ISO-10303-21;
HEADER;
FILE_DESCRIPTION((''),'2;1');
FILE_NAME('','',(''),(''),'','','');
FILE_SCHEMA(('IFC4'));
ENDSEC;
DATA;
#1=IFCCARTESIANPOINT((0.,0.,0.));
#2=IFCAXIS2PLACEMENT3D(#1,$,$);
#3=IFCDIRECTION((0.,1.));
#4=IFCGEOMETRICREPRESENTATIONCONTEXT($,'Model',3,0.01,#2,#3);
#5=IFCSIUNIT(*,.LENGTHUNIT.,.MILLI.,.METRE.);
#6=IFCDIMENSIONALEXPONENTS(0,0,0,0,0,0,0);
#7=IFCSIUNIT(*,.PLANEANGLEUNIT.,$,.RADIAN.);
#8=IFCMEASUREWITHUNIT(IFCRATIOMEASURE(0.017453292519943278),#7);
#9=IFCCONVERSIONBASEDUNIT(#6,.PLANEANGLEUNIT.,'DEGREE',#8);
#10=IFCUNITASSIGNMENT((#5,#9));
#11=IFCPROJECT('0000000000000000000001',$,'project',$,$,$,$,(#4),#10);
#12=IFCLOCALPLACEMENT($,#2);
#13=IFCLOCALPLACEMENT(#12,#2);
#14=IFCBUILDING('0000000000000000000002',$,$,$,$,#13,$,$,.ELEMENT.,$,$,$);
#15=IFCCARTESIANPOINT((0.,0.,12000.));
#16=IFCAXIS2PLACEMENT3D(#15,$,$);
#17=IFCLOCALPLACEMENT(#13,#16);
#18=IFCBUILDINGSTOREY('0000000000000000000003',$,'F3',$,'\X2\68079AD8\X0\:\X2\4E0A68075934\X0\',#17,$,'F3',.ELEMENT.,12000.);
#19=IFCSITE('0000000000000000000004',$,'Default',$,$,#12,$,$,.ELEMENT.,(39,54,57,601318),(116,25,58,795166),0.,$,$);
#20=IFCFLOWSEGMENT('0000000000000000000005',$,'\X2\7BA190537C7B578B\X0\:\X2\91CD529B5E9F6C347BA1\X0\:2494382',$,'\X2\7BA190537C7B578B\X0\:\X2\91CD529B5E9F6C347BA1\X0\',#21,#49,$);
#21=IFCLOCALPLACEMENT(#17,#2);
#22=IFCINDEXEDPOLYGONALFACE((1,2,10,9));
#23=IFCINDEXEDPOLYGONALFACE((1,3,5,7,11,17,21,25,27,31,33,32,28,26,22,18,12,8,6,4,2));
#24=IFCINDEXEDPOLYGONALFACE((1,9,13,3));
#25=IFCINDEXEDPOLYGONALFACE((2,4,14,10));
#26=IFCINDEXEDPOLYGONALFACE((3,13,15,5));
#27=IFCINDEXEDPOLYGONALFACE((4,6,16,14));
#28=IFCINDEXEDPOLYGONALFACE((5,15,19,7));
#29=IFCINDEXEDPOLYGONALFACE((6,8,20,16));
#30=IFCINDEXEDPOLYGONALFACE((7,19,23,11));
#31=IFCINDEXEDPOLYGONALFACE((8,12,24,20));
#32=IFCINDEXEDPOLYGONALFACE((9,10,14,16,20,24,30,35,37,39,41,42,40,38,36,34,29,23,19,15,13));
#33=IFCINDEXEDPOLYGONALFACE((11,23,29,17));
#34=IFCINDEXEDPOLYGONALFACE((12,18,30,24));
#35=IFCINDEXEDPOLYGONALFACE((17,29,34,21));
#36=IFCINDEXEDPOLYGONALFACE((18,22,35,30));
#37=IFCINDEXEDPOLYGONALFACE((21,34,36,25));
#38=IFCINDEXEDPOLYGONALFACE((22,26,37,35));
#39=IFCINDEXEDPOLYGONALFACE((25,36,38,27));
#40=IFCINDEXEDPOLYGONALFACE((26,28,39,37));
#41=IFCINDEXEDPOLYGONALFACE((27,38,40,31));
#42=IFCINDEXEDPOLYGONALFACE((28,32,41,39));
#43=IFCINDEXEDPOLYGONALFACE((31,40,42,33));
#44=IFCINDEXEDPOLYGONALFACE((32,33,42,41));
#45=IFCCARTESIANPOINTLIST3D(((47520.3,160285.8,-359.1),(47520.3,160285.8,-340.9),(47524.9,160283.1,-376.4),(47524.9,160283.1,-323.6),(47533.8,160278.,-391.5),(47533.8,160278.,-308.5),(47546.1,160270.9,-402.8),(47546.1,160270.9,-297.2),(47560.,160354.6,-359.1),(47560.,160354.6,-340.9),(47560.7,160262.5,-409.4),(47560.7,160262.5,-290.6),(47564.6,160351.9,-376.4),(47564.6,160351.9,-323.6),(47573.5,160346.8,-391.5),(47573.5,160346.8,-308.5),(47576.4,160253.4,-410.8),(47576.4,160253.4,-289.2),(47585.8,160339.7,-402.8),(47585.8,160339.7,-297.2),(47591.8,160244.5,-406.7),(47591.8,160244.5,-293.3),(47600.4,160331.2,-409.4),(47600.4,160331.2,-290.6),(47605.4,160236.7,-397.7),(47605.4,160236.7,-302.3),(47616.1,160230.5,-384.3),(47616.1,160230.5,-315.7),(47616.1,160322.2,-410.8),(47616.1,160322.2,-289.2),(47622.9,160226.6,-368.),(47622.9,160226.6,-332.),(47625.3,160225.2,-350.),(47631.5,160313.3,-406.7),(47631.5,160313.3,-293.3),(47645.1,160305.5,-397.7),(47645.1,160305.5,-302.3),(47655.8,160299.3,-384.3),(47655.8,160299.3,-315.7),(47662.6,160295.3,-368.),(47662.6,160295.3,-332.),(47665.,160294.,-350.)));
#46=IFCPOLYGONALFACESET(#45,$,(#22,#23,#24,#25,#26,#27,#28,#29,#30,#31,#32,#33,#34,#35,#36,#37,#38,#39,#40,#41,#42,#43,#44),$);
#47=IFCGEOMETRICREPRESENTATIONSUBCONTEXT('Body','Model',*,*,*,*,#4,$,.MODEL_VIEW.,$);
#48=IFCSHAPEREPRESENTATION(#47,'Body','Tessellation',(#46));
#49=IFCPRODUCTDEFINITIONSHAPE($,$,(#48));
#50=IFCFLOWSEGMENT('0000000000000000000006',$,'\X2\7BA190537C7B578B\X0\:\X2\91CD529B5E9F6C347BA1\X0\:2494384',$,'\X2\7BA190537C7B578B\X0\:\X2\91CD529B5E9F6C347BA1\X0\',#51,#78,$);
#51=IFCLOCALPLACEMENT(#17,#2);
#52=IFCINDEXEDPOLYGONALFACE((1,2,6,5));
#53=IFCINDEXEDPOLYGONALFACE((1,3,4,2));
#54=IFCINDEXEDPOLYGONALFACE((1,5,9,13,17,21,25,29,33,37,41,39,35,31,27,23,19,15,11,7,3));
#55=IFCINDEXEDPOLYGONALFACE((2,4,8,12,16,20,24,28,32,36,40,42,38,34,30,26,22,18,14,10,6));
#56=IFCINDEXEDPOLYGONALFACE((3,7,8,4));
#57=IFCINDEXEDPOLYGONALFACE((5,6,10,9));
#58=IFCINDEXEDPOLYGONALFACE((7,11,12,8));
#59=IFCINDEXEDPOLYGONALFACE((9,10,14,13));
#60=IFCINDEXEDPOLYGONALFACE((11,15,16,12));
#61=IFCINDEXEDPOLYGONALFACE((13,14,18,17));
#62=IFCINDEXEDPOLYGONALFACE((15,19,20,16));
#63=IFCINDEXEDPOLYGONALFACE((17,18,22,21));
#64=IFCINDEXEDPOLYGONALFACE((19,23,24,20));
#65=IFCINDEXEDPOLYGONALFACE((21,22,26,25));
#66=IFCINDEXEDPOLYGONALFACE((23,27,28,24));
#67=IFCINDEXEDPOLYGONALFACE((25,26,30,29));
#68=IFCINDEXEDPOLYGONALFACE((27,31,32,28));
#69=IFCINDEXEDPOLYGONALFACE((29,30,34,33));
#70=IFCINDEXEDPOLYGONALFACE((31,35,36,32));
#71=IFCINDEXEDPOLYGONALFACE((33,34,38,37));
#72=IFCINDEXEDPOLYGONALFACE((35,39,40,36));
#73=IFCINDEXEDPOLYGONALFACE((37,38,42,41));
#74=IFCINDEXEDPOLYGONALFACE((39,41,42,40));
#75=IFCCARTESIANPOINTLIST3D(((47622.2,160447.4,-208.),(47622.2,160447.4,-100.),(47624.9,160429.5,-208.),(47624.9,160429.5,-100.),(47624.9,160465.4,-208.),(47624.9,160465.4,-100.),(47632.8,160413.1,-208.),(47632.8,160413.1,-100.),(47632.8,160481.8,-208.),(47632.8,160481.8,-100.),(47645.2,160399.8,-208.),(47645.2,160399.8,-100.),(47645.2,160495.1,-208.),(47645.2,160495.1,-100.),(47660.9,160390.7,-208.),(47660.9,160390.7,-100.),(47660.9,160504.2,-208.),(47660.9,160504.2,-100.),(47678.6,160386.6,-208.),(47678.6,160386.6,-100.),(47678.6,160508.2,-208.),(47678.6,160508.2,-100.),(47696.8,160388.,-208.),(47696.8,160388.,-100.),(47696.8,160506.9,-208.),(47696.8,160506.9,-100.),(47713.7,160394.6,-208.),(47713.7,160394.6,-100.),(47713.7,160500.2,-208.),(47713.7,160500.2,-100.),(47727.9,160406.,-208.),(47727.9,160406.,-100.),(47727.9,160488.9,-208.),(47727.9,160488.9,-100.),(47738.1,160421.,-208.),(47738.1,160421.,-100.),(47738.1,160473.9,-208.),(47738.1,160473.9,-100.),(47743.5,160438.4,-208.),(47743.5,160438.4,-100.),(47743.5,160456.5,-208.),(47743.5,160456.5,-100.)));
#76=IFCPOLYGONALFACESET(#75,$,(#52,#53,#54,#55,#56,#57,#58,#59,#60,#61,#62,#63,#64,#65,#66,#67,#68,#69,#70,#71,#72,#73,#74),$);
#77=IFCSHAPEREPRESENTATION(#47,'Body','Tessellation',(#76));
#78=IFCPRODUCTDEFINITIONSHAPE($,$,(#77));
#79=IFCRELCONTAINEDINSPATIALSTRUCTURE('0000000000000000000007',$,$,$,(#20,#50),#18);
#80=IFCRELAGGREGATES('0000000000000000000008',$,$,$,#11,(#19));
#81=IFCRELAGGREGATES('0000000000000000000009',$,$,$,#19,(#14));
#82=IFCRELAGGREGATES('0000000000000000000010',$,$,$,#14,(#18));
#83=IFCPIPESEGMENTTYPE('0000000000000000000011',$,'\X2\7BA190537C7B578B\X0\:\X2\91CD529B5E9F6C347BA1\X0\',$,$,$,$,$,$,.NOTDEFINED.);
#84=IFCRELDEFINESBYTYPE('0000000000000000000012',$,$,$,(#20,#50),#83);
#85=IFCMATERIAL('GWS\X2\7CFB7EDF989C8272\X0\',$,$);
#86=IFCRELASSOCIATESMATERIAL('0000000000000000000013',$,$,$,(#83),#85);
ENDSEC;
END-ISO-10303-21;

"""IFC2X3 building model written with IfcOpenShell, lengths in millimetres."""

from ifc_helpers import new_model, entity, si_unit, converted_unit, direction, frame, frame_2d, origin, origin_2d_with_axis, place, context, subcontext, project, spatial, circle, extrude, material, type_object, element, save


model = new_model("IFC2X3")

# Units and contexts
model_context = context("Model", 3, precision=0.01, world=origin(), true_north=direction((0.0, 1.0)))
body_context = subcontext(model_context, "Body", "Model", "MODEL_VIEW")
ifc_project = project(units=[si_unit("LENGTHUNIT", "METRE", prefix="MILLI"), converted_unit("PLANEANGLEUNIT", "DEGREE", entity("IfcRatioMeasure", 0.017453292519943278), si_unit("PLANEANGLEUNIT", "RADIAN"), dimensions=[0, 0, 0, 0, 0, 0, 0])], contexts=[model_context])

# Site, building, storey
site_placement = place(None, origin())
site = spatial("IfcSite", under=ifc_project, at=site_placement, Name="Default", CompositionType="ELEMENT", RefLatitude=(39, 54, 57, 601318), RefLongitude=(116, 25, 58, 795166), RefElevation=0.0)
building_placement = place(site_placement, origin())
building = spatial("IfcBuilding", under=site, at=building_placement, CompositionType="ELEMENT")
storey_placement = place(building_placement, frame((0.0, 0.0, 12000.0)))
storey = spatial("IfcBuildingStorey", under=building, at=storey_placement, Name="F3", ObjectType="标高:上标头", LongName="F3", CompositionType="ELEMENT", Elevation=12000.0)

# Flow segments
ifc_material = material(Name="GWS系统颜色")
pipe_segment_type = type_object("IfcPipeSegmentType", Name="管道类型:重力废水管", PredefinedType="NOTDEFINED", material=ifc_material)
flow_segment_1_placement = place(storey_placement, origin())
element("IfcFlowSegment", 1, at=flow_segment_1_placement, inside=storey, type_object=pipe_segment_type, Name="管道类型:重力废水管:2494382", ObjectType="管道类型:重力废水管", context=body_context, shape_type="SweptSolid", body=[
    extrude(circle(Radius=61.0, at=frame_2d((0.0, 0.0), x_axis=(1.0, 0.0))), frame((47572.5, 160255.7, -350.0), z_axis=(0.5, 0.866025, 0.0), x_axis=(0.866025, -0.5, 0.0)), (0.0, 0.0, 1.0), 79.4),
])
flow_segment_2_placement = place(storey_placement, origin())
element("IfcFlowSegment", 2, at=flow_segment_2_placement, inside=storey, type_object=pipe_segment_type, Name="管道类型:重力废水管:2494384", ObjectType="管道类型:重力废水管", context=body_context, shape_type="SweptSolid", body=[
    extrude(circle(Radius=61.0, at=origin_2d_with_axis()), frame((47683.2, 160447.4, -208.0), z_axis=(0.0, 0.0, 1.0), x_axis=(-1.0, 0.0, 0.0)), (0.0, 0.0, 1.0), 108.0),
])

save(model, "model.ifc")
